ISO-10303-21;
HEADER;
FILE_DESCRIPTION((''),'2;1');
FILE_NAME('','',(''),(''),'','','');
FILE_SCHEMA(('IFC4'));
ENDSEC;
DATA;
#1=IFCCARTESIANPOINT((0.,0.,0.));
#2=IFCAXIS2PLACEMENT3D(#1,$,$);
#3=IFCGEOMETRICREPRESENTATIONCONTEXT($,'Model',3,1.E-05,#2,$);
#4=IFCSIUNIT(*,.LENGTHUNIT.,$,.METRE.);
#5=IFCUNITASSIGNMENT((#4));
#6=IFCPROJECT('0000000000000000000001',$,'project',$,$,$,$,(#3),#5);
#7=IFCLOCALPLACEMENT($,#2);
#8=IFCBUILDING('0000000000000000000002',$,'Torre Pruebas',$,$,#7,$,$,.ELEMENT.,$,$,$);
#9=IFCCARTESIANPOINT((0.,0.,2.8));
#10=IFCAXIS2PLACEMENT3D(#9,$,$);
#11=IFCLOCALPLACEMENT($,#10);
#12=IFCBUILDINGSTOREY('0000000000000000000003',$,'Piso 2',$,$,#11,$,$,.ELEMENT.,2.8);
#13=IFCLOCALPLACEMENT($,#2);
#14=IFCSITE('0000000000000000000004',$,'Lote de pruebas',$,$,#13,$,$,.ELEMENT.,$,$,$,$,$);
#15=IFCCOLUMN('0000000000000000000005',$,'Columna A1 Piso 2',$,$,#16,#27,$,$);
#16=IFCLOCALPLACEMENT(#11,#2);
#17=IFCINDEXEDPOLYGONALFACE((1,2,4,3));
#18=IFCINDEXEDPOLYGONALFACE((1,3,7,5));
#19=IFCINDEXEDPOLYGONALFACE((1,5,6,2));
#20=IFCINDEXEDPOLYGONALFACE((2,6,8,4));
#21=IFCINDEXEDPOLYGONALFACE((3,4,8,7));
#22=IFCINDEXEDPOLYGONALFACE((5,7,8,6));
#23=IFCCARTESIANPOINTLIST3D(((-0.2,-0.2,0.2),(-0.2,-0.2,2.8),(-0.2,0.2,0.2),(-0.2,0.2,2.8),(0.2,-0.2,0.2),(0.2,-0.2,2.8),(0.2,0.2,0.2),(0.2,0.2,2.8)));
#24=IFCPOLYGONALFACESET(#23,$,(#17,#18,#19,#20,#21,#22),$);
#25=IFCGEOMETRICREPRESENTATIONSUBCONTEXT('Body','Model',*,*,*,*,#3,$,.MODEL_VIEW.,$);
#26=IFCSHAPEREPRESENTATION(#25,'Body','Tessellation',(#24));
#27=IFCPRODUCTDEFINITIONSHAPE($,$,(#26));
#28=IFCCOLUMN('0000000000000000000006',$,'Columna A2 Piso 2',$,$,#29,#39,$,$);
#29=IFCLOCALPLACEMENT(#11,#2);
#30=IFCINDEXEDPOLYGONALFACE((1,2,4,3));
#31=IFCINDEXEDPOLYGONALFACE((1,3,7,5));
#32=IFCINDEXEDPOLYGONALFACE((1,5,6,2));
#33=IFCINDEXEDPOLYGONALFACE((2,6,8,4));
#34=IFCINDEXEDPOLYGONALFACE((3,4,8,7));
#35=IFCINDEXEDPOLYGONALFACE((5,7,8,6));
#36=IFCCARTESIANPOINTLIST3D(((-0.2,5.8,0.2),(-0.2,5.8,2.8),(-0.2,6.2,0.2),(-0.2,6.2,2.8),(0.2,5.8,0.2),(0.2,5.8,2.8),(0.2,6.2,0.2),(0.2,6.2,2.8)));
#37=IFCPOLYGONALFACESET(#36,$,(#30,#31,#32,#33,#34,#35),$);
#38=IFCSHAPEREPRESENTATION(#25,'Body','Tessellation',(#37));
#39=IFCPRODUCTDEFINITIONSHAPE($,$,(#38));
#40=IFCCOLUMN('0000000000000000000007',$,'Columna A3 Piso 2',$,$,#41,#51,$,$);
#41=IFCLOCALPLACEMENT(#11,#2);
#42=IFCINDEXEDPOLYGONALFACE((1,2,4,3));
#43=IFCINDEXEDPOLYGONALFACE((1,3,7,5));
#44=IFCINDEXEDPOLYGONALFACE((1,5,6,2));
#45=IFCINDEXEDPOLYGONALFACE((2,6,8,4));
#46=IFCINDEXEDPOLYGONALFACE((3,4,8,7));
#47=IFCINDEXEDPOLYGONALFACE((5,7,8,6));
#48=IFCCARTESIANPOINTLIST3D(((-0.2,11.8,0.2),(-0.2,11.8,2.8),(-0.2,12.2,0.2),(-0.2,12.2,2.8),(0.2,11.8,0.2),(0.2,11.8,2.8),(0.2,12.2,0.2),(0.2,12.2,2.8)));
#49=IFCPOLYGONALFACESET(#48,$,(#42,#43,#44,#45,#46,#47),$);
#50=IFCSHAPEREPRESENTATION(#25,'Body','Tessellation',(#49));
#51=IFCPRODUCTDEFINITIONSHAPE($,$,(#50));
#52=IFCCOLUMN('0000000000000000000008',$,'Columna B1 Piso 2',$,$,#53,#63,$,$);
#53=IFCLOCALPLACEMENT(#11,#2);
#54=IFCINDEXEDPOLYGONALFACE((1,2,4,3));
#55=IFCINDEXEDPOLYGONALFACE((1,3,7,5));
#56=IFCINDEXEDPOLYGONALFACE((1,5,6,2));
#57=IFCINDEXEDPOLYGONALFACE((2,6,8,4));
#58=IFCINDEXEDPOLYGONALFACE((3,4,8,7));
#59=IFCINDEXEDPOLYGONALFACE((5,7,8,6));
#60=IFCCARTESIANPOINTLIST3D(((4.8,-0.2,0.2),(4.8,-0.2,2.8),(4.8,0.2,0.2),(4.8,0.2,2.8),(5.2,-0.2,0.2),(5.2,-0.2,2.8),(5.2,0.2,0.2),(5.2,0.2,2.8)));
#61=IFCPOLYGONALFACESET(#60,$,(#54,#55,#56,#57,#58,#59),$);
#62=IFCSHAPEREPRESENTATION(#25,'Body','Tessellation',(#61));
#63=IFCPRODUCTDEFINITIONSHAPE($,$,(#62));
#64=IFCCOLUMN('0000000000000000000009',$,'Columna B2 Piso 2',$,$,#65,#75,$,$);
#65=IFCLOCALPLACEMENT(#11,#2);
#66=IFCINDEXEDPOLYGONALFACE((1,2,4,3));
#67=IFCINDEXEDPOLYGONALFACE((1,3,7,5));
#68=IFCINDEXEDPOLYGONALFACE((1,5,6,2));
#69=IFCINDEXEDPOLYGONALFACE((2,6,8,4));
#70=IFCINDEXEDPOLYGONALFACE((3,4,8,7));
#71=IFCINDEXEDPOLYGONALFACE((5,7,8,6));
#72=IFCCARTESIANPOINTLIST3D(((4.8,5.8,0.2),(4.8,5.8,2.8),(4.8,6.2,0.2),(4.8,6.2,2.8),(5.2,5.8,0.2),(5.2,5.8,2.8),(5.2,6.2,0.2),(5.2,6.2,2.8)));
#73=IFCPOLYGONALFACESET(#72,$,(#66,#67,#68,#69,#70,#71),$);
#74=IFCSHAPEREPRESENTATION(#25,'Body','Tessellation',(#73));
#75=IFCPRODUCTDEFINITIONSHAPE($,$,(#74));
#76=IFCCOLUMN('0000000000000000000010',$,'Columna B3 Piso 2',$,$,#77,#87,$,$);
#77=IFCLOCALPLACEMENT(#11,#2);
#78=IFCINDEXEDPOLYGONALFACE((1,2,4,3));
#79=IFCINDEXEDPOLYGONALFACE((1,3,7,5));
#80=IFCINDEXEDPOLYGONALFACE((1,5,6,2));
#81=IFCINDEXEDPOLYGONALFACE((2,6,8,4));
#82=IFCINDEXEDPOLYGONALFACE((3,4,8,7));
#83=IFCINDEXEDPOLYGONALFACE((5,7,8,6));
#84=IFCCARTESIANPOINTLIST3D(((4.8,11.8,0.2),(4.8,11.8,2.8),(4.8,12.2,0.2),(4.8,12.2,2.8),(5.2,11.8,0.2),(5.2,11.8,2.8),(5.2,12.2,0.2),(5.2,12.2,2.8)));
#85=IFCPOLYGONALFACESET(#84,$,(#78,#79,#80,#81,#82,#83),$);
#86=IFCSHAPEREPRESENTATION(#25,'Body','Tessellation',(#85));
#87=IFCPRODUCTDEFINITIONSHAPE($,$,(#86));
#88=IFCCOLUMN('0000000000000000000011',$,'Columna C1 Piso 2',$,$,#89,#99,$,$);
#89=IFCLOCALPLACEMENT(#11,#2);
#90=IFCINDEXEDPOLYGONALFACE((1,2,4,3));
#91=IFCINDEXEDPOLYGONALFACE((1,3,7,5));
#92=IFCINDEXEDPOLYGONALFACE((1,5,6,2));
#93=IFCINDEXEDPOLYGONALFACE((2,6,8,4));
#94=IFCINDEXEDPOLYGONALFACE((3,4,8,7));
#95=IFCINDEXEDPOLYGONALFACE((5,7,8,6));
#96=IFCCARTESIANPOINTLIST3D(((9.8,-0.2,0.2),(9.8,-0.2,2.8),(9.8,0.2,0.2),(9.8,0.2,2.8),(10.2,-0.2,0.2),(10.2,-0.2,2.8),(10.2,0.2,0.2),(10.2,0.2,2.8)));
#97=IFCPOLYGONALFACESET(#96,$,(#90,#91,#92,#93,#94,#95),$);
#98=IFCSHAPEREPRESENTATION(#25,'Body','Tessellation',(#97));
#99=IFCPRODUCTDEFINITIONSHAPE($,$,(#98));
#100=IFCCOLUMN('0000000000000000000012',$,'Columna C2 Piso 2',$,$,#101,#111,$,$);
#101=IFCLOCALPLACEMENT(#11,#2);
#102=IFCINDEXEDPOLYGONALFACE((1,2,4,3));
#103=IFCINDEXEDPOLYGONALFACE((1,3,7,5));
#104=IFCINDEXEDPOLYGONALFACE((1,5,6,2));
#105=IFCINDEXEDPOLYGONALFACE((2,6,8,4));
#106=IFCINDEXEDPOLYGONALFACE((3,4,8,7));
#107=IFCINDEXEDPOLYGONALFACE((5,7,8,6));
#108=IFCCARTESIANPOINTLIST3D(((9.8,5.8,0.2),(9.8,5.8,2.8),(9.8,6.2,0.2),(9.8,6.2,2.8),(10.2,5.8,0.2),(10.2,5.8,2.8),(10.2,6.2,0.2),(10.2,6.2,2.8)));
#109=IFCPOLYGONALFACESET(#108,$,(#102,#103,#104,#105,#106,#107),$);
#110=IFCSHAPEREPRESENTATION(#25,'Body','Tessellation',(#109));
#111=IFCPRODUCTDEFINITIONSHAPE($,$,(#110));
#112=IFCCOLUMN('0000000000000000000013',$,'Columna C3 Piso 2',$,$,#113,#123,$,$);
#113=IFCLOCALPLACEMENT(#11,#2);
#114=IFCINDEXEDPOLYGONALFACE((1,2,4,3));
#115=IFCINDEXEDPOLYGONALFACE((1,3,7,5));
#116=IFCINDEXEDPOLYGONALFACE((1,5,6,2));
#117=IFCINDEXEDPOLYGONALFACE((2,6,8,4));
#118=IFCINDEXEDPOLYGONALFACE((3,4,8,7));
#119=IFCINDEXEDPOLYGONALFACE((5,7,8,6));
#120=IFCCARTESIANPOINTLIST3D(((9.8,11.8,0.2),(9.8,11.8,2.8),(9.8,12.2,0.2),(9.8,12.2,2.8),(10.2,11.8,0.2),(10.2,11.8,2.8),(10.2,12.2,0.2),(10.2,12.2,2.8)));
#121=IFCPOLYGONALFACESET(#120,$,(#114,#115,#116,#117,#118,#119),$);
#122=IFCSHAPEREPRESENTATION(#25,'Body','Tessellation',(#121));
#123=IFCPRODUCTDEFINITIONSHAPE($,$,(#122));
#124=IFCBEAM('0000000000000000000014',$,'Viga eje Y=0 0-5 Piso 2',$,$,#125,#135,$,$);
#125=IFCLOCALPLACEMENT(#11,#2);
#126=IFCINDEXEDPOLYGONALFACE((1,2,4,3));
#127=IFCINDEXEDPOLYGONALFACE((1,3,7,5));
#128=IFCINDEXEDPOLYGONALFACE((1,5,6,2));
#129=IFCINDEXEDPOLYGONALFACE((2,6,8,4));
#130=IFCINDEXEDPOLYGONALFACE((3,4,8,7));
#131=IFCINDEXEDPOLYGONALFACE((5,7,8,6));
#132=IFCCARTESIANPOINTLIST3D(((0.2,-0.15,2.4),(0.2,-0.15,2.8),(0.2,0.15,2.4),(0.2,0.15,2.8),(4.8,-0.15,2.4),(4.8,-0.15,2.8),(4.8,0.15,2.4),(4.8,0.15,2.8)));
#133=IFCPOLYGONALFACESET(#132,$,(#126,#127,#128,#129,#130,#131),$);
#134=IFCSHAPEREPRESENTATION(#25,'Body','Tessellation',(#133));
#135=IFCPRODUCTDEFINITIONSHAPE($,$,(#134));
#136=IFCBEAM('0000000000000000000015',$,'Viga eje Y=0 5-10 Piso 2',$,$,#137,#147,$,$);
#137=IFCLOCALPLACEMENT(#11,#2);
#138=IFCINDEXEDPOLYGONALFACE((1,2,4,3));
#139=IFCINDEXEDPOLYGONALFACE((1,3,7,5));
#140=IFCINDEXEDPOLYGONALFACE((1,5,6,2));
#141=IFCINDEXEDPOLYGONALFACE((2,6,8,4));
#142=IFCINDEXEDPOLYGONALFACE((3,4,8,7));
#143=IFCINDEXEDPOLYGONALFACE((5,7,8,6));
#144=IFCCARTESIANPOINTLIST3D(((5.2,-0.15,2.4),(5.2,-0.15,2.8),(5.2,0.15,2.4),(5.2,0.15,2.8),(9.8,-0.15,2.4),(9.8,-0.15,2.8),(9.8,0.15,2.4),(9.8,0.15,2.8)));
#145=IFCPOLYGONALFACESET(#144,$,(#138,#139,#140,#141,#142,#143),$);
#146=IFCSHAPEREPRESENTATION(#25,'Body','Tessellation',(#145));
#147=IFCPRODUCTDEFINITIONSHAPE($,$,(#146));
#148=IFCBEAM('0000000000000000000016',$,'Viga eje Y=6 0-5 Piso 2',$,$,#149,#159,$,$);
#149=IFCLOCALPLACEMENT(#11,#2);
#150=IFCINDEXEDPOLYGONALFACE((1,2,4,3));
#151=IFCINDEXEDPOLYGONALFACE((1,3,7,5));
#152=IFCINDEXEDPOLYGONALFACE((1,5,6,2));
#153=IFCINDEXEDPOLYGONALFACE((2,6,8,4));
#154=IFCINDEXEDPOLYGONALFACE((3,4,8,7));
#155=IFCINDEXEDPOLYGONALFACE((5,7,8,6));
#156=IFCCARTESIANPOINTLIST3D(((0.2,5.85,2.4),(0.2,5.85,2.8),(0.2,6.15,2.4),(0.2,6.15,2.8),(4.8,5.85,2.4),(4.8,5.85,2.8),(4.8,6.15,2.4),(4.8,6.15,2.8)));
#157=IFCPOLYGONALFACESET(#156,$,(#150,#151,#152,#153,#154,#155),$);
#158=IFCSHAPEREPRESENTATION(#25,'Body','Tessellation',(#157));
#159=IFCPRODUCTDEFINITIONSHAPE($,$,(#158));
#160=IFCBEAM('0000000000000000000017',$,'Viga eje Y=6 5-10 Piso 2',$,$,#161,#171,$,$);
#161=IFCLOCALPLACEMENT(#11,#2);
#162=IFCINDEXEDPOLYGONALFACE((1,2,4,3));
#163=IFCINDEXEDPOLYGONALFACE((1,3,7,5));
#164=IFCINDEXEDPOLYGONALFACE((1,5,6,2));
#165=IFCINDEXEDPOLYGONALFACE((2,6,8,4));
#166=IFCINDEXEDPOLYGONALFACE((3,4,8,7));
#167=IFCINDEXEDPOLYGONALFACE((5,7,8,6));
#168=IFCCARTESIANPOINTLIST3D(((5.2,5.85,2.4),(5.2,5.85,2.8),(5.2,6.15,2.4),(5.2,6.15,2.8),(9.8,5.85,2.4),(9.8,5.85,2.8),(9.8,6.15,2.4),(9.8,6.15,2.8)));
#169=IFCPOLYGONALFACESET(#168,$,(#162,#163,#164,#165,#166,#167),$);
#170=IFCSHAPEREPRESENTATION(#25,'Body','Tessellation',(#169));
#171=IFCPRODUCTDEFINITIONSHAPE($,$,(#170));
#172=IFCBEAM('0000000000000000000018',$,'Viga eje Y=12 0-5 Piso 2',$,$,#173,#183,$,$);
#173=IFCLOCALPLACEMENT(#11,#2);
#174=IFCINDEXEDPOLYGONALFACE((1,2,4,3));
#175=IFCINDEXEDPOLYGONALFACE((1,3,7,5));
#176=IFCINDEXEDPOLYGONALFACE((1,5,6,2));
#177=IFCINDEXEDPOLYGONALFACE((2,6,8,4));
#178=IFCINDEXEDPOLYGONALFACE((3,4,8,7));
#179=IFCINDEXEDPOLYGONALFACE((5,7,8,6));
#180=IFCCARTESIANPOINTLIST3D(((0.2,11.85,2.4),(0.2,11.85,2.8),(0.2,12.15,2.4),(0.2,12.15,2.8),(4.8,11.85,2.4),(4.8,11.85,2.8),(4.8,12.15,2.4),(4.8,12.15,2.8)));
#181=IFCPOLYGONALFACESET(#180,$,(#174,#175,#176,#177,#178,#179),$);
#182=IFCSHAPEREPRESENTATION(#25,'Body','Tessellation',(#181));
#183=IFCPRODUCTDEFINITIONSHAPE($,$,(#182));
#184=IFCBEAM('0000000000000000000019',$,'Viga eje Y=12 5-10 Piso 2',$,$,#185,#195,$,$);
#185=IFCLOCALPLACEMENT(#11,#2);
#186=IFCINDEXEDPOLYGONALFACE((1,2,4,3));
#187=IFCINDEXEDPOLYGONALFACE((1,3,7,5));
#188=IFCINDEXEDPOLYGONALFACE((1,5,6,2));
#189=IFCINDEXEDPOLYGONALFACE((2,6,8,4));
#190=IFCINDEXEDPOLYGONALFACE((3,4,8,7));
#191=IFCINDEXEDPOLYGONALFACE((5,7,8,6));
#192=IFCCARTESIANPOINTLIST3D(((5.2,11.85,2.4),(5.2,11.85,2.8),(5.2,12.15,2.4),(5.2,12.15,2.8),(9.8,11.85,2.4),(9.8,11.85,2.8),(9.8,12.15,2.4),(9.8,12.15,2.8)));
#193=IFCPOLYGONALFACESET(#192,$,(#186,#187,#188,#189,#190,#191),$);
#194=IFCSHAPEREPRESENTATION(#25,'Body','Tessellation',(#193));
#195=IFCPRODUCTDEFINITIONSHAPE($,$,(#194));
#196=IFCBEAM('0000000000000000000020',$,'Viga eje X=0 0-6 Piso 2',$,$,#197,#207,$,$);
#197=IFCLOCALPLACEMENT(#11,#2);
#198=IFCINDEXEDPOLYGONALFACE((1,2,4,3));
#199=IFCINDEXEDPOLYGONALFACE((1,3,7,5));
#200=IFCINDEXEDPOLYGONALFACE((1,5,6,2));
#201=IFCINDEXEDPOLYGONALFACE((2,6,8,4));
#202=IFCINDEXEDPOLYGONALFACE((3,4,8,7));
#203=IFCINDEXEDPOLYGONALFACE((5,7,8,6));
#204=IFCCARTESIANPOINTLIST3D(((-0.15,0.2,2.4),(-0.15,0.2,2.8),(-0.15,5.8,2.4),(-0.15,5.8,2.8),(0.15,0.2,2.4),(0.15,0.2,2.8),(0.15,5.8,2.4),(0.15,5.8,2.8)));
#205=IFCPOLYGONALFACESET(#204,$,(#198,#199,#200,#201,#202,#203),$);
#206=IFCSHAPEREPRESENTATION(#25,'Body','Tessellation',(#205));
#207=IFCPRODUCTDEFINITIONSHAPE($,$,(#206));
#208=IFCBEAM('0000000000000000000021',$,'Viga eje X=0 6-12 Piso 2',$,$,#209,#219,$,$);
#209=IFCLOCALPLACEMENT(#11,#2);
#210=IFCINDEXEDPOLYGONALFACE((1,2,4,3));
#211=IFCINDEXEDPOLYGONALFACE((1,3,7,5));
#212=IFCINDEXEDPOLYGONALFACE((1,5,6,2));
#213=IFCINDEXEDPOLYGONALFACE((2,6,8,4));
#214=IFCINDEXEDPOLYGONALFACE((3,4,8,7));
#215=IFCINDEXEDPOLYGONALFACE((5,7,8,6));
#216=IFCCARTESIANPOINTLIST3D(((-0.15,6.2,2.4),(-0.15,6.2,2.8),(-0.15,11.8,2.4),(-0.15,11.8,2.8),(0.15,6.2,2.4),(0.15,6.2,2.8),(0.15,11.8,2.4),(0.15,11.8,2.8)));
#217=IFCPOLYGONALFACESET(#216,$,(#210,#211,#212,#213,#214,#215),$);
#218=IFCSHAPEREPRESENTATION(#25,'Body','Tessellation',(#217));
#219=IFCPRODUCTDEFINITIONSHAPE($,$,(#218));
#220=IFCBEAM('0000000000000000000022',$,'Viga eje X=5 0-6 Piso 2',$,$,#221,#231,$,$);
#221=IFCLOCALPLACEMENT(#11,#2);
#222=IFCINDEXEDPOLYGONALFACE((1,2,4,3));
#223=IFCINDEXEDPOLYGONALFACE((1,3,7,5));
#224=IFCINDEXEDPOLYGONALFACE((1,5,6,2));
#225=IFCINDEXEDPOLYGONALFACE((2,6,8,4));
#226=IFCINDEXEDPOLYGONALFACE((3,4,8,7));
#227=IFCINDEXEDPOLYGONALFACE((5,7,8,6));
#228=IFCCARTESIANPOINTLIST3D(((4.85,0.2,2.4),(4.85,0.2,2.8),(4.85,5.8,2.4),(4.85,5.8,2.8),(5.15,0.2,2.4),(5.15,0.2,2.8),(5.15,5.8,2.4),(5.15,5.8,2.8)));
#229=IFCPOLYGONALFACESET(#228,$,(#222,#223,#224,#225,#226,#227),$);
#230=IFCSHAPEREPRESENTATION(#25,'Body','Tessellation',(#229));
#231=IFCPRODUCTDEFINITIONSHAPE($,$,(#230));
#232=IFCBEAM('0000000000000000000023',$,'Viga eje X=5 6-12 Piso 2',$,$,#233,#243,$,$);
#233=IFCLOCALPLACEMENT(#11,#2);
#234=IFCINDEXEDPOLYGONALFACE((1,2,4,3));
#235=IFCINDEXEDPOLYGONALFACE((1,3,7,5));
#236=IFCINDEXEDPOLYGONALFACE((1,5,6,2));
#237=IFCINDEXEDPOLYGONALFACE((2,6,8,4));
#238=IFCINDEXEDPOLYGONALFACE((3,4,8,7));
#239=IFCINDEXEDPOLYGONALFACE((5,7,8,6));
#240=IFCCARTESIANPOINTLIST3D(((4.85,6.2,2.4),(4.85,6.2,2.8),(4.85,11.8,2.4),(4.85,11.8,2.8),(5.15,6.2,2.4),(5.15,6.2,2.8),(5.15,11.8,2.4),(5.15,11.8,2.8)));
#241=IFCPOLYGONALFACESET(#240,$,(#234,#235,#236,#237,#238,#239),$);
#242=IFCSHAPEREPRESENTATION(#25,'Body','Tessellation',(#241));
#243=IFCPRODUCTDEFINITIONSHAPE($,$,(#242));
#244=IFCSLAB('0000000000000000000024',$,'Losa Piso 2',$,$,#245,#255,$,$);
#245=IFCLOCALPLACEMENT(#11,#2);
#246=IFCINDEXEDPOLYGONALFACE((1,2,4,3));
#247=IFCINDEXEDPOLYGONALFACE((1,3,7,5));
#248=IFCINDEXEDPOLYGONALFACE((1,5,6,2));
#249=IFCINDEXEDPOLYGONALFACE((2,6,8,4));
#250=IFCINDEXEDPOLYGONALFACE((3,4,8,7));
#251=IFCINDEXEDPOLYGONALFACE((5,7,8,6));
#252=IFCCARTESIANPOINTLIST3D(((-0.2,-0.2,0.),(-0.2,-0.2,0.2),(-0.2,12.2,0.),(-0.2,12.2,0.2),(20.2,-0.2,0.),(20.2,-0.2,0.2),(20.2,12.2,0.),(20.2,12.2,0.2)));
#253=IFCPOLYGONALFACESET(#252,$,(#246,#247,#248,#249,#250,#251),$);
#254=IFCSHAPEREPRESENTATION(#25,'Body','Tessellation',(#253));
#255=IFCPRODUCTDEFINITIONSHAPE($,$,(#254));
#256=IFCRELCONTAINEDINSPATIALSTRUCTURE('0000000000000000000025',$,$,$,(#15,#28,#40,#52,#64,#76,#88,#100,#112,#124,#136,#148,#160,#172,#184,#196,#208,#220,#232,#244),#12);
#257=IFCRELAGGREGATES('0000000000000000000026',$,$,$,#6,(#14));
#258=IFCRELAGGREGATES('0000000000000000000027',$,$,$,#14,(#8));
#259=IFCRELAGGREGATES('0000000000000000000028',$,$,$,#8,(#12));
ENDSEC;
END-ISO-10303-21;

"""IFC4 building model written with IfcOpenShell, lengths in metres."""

from ifc_helpers import new_model, si_unit, frame, origin, origin_2d, place, context, subcontext, project, spatial, rectangle, extrude, element, save


model = new_model("IFC4")

# Units and contexts
model_context = context("Model", 3, precision=1e-05, world=origin())
body_context = subcontext(model_context, "Body", "Model", "MODEL_VIEW")
ifc_project = project(units=[si_unit("LENGTHUNIT", "METRE")], contexts=[model_context])

# Site, building, storey
site_placement = place(None, origin())
site = spatial("IfcSite", under=ifc_project, at=site_placement, Name="Lote de pruebas", CompositionType="ELEMENT")
building_placement = place(None, origin())
building = spatial("IfcBuilding", under=site, at=building_placement, Name="Torre Pruebas", CompositionType="ELEMENT")
storey_placement = place(None, frame((0.0, 0.0, 2.8)))
storey = spatial("IfcBuildingStorey", under=building, at=storey_placement, Name="Piso 2", CompositionType="ELEMENT", Elevation=2.8)

# Columns
for number, where, name in (
    (1, (0.0, 0.0, 3.0), "Columna A1 Piso 2"),
    (2, (0.0, 6.0, 3.0), "Columna A2 Piso 2"),
    (3, (0.0, 12.0, 3.0), "Columna A3 Piso 2"),
    (4, (5.0, 0.0, 3.0), "Columna B1 Piso 2"),
    (5, (5.0, 6.0, 3.0), "Columna B2 Piso 2"),
    (6, (5.0, 12.0, 3.0), "Columna B3 Piso 2"),
    (7, (10.0, 0.0, 3.0), "Columna C1 Piso 2"),
    (8, (10.0, 6.0, 3.0), "Columna C2 Piso 2"),
    (9, (10.0, 12.0, 3.0), "Columna C3 Piso 2"),
):
    element("IfcColumn", number, at=place(None, frame(where)), inside=storey, Name=name, context=body_context, shape_type="SweptSolid", body=[
        extrude(rectangle(XDim=0.4, YDim=0.4, at=origin_2d()), origin(), (0.0, 0.0, 1.0), 2.6),
    ])

# Beams
for number, where, name in (
    (10, (2.5, 0.0, 5.2), "Viga eje Y=0 0-5 Piso 2"),
    (11, (7.5, 0.0, 5.2), "Viga eje Y=0 5-10 Piso 2"),
    (12, (2.5, 6.0, 5.2), "Viga eje Y=6 0-5 Piso 2"),
    (13, (7.5, 6.0, 5.2), "Viga eje Y=6 5-10 Piso 2"),
    (14, (2.5, 12.0, 5.2), "Viga eje Y=12 0-5 Piso 2"),
    (15, (7.5, 12.0, 5.2), "Viga eje Y=12 5-10 Piso 2"),
):
    element("IfcBeam", number, at=place(None, frame(where)), inside=storey, Name=name, context=body_context, shape_type="SweptSolid", body=[
        extrude(rectangle(XDim=4.6, YDim=0.3, at=origin_2d()), origin(), (0.0, 0.0, 1.0), 0.4),
    ])
for number, where, name in (
    (16, (0.0, 3.0, 5.2), "Viga eje X=0 0-6 Piso 2"),
    (17, (0.0, 9.0, 5.2), "Viga eje X=0 6-12 Piso 2"),
    (18, (5.0, 3.0, 5.2), "Viga eje X=5 0-6 Piso 2"),
    (19, (5.0, 9.0, 5.2), "Viga eje X=5 6-12 Piso 2"),
):
    element("IfcBeam", number, at=place(None, frame(where)), inside=storey, Name=name, context=body_context, shape_type="SweptSolid", body=[
        extrude(rectangle(XDim=0.3, YDim=5.6, at=origin_2d()), origin(), (0.0, 0.0, 1.0), 0.4),
    ])

# Slab
slab_placement = place(None, frame((10.0, 6.0, 2.8)))
element("IfcSlab", 20, at=slab_placement, inside=storey, Name="Losa Piso 2", context=body_context, shape_type="SweptSolid", body=[
    extrude(rectangle(XDim=20.4, YDim=12.4, at=origin_2d()), origin(), (0.0, 0.0, 1.0), 0.2),
])

save(model, "model.ifc")
